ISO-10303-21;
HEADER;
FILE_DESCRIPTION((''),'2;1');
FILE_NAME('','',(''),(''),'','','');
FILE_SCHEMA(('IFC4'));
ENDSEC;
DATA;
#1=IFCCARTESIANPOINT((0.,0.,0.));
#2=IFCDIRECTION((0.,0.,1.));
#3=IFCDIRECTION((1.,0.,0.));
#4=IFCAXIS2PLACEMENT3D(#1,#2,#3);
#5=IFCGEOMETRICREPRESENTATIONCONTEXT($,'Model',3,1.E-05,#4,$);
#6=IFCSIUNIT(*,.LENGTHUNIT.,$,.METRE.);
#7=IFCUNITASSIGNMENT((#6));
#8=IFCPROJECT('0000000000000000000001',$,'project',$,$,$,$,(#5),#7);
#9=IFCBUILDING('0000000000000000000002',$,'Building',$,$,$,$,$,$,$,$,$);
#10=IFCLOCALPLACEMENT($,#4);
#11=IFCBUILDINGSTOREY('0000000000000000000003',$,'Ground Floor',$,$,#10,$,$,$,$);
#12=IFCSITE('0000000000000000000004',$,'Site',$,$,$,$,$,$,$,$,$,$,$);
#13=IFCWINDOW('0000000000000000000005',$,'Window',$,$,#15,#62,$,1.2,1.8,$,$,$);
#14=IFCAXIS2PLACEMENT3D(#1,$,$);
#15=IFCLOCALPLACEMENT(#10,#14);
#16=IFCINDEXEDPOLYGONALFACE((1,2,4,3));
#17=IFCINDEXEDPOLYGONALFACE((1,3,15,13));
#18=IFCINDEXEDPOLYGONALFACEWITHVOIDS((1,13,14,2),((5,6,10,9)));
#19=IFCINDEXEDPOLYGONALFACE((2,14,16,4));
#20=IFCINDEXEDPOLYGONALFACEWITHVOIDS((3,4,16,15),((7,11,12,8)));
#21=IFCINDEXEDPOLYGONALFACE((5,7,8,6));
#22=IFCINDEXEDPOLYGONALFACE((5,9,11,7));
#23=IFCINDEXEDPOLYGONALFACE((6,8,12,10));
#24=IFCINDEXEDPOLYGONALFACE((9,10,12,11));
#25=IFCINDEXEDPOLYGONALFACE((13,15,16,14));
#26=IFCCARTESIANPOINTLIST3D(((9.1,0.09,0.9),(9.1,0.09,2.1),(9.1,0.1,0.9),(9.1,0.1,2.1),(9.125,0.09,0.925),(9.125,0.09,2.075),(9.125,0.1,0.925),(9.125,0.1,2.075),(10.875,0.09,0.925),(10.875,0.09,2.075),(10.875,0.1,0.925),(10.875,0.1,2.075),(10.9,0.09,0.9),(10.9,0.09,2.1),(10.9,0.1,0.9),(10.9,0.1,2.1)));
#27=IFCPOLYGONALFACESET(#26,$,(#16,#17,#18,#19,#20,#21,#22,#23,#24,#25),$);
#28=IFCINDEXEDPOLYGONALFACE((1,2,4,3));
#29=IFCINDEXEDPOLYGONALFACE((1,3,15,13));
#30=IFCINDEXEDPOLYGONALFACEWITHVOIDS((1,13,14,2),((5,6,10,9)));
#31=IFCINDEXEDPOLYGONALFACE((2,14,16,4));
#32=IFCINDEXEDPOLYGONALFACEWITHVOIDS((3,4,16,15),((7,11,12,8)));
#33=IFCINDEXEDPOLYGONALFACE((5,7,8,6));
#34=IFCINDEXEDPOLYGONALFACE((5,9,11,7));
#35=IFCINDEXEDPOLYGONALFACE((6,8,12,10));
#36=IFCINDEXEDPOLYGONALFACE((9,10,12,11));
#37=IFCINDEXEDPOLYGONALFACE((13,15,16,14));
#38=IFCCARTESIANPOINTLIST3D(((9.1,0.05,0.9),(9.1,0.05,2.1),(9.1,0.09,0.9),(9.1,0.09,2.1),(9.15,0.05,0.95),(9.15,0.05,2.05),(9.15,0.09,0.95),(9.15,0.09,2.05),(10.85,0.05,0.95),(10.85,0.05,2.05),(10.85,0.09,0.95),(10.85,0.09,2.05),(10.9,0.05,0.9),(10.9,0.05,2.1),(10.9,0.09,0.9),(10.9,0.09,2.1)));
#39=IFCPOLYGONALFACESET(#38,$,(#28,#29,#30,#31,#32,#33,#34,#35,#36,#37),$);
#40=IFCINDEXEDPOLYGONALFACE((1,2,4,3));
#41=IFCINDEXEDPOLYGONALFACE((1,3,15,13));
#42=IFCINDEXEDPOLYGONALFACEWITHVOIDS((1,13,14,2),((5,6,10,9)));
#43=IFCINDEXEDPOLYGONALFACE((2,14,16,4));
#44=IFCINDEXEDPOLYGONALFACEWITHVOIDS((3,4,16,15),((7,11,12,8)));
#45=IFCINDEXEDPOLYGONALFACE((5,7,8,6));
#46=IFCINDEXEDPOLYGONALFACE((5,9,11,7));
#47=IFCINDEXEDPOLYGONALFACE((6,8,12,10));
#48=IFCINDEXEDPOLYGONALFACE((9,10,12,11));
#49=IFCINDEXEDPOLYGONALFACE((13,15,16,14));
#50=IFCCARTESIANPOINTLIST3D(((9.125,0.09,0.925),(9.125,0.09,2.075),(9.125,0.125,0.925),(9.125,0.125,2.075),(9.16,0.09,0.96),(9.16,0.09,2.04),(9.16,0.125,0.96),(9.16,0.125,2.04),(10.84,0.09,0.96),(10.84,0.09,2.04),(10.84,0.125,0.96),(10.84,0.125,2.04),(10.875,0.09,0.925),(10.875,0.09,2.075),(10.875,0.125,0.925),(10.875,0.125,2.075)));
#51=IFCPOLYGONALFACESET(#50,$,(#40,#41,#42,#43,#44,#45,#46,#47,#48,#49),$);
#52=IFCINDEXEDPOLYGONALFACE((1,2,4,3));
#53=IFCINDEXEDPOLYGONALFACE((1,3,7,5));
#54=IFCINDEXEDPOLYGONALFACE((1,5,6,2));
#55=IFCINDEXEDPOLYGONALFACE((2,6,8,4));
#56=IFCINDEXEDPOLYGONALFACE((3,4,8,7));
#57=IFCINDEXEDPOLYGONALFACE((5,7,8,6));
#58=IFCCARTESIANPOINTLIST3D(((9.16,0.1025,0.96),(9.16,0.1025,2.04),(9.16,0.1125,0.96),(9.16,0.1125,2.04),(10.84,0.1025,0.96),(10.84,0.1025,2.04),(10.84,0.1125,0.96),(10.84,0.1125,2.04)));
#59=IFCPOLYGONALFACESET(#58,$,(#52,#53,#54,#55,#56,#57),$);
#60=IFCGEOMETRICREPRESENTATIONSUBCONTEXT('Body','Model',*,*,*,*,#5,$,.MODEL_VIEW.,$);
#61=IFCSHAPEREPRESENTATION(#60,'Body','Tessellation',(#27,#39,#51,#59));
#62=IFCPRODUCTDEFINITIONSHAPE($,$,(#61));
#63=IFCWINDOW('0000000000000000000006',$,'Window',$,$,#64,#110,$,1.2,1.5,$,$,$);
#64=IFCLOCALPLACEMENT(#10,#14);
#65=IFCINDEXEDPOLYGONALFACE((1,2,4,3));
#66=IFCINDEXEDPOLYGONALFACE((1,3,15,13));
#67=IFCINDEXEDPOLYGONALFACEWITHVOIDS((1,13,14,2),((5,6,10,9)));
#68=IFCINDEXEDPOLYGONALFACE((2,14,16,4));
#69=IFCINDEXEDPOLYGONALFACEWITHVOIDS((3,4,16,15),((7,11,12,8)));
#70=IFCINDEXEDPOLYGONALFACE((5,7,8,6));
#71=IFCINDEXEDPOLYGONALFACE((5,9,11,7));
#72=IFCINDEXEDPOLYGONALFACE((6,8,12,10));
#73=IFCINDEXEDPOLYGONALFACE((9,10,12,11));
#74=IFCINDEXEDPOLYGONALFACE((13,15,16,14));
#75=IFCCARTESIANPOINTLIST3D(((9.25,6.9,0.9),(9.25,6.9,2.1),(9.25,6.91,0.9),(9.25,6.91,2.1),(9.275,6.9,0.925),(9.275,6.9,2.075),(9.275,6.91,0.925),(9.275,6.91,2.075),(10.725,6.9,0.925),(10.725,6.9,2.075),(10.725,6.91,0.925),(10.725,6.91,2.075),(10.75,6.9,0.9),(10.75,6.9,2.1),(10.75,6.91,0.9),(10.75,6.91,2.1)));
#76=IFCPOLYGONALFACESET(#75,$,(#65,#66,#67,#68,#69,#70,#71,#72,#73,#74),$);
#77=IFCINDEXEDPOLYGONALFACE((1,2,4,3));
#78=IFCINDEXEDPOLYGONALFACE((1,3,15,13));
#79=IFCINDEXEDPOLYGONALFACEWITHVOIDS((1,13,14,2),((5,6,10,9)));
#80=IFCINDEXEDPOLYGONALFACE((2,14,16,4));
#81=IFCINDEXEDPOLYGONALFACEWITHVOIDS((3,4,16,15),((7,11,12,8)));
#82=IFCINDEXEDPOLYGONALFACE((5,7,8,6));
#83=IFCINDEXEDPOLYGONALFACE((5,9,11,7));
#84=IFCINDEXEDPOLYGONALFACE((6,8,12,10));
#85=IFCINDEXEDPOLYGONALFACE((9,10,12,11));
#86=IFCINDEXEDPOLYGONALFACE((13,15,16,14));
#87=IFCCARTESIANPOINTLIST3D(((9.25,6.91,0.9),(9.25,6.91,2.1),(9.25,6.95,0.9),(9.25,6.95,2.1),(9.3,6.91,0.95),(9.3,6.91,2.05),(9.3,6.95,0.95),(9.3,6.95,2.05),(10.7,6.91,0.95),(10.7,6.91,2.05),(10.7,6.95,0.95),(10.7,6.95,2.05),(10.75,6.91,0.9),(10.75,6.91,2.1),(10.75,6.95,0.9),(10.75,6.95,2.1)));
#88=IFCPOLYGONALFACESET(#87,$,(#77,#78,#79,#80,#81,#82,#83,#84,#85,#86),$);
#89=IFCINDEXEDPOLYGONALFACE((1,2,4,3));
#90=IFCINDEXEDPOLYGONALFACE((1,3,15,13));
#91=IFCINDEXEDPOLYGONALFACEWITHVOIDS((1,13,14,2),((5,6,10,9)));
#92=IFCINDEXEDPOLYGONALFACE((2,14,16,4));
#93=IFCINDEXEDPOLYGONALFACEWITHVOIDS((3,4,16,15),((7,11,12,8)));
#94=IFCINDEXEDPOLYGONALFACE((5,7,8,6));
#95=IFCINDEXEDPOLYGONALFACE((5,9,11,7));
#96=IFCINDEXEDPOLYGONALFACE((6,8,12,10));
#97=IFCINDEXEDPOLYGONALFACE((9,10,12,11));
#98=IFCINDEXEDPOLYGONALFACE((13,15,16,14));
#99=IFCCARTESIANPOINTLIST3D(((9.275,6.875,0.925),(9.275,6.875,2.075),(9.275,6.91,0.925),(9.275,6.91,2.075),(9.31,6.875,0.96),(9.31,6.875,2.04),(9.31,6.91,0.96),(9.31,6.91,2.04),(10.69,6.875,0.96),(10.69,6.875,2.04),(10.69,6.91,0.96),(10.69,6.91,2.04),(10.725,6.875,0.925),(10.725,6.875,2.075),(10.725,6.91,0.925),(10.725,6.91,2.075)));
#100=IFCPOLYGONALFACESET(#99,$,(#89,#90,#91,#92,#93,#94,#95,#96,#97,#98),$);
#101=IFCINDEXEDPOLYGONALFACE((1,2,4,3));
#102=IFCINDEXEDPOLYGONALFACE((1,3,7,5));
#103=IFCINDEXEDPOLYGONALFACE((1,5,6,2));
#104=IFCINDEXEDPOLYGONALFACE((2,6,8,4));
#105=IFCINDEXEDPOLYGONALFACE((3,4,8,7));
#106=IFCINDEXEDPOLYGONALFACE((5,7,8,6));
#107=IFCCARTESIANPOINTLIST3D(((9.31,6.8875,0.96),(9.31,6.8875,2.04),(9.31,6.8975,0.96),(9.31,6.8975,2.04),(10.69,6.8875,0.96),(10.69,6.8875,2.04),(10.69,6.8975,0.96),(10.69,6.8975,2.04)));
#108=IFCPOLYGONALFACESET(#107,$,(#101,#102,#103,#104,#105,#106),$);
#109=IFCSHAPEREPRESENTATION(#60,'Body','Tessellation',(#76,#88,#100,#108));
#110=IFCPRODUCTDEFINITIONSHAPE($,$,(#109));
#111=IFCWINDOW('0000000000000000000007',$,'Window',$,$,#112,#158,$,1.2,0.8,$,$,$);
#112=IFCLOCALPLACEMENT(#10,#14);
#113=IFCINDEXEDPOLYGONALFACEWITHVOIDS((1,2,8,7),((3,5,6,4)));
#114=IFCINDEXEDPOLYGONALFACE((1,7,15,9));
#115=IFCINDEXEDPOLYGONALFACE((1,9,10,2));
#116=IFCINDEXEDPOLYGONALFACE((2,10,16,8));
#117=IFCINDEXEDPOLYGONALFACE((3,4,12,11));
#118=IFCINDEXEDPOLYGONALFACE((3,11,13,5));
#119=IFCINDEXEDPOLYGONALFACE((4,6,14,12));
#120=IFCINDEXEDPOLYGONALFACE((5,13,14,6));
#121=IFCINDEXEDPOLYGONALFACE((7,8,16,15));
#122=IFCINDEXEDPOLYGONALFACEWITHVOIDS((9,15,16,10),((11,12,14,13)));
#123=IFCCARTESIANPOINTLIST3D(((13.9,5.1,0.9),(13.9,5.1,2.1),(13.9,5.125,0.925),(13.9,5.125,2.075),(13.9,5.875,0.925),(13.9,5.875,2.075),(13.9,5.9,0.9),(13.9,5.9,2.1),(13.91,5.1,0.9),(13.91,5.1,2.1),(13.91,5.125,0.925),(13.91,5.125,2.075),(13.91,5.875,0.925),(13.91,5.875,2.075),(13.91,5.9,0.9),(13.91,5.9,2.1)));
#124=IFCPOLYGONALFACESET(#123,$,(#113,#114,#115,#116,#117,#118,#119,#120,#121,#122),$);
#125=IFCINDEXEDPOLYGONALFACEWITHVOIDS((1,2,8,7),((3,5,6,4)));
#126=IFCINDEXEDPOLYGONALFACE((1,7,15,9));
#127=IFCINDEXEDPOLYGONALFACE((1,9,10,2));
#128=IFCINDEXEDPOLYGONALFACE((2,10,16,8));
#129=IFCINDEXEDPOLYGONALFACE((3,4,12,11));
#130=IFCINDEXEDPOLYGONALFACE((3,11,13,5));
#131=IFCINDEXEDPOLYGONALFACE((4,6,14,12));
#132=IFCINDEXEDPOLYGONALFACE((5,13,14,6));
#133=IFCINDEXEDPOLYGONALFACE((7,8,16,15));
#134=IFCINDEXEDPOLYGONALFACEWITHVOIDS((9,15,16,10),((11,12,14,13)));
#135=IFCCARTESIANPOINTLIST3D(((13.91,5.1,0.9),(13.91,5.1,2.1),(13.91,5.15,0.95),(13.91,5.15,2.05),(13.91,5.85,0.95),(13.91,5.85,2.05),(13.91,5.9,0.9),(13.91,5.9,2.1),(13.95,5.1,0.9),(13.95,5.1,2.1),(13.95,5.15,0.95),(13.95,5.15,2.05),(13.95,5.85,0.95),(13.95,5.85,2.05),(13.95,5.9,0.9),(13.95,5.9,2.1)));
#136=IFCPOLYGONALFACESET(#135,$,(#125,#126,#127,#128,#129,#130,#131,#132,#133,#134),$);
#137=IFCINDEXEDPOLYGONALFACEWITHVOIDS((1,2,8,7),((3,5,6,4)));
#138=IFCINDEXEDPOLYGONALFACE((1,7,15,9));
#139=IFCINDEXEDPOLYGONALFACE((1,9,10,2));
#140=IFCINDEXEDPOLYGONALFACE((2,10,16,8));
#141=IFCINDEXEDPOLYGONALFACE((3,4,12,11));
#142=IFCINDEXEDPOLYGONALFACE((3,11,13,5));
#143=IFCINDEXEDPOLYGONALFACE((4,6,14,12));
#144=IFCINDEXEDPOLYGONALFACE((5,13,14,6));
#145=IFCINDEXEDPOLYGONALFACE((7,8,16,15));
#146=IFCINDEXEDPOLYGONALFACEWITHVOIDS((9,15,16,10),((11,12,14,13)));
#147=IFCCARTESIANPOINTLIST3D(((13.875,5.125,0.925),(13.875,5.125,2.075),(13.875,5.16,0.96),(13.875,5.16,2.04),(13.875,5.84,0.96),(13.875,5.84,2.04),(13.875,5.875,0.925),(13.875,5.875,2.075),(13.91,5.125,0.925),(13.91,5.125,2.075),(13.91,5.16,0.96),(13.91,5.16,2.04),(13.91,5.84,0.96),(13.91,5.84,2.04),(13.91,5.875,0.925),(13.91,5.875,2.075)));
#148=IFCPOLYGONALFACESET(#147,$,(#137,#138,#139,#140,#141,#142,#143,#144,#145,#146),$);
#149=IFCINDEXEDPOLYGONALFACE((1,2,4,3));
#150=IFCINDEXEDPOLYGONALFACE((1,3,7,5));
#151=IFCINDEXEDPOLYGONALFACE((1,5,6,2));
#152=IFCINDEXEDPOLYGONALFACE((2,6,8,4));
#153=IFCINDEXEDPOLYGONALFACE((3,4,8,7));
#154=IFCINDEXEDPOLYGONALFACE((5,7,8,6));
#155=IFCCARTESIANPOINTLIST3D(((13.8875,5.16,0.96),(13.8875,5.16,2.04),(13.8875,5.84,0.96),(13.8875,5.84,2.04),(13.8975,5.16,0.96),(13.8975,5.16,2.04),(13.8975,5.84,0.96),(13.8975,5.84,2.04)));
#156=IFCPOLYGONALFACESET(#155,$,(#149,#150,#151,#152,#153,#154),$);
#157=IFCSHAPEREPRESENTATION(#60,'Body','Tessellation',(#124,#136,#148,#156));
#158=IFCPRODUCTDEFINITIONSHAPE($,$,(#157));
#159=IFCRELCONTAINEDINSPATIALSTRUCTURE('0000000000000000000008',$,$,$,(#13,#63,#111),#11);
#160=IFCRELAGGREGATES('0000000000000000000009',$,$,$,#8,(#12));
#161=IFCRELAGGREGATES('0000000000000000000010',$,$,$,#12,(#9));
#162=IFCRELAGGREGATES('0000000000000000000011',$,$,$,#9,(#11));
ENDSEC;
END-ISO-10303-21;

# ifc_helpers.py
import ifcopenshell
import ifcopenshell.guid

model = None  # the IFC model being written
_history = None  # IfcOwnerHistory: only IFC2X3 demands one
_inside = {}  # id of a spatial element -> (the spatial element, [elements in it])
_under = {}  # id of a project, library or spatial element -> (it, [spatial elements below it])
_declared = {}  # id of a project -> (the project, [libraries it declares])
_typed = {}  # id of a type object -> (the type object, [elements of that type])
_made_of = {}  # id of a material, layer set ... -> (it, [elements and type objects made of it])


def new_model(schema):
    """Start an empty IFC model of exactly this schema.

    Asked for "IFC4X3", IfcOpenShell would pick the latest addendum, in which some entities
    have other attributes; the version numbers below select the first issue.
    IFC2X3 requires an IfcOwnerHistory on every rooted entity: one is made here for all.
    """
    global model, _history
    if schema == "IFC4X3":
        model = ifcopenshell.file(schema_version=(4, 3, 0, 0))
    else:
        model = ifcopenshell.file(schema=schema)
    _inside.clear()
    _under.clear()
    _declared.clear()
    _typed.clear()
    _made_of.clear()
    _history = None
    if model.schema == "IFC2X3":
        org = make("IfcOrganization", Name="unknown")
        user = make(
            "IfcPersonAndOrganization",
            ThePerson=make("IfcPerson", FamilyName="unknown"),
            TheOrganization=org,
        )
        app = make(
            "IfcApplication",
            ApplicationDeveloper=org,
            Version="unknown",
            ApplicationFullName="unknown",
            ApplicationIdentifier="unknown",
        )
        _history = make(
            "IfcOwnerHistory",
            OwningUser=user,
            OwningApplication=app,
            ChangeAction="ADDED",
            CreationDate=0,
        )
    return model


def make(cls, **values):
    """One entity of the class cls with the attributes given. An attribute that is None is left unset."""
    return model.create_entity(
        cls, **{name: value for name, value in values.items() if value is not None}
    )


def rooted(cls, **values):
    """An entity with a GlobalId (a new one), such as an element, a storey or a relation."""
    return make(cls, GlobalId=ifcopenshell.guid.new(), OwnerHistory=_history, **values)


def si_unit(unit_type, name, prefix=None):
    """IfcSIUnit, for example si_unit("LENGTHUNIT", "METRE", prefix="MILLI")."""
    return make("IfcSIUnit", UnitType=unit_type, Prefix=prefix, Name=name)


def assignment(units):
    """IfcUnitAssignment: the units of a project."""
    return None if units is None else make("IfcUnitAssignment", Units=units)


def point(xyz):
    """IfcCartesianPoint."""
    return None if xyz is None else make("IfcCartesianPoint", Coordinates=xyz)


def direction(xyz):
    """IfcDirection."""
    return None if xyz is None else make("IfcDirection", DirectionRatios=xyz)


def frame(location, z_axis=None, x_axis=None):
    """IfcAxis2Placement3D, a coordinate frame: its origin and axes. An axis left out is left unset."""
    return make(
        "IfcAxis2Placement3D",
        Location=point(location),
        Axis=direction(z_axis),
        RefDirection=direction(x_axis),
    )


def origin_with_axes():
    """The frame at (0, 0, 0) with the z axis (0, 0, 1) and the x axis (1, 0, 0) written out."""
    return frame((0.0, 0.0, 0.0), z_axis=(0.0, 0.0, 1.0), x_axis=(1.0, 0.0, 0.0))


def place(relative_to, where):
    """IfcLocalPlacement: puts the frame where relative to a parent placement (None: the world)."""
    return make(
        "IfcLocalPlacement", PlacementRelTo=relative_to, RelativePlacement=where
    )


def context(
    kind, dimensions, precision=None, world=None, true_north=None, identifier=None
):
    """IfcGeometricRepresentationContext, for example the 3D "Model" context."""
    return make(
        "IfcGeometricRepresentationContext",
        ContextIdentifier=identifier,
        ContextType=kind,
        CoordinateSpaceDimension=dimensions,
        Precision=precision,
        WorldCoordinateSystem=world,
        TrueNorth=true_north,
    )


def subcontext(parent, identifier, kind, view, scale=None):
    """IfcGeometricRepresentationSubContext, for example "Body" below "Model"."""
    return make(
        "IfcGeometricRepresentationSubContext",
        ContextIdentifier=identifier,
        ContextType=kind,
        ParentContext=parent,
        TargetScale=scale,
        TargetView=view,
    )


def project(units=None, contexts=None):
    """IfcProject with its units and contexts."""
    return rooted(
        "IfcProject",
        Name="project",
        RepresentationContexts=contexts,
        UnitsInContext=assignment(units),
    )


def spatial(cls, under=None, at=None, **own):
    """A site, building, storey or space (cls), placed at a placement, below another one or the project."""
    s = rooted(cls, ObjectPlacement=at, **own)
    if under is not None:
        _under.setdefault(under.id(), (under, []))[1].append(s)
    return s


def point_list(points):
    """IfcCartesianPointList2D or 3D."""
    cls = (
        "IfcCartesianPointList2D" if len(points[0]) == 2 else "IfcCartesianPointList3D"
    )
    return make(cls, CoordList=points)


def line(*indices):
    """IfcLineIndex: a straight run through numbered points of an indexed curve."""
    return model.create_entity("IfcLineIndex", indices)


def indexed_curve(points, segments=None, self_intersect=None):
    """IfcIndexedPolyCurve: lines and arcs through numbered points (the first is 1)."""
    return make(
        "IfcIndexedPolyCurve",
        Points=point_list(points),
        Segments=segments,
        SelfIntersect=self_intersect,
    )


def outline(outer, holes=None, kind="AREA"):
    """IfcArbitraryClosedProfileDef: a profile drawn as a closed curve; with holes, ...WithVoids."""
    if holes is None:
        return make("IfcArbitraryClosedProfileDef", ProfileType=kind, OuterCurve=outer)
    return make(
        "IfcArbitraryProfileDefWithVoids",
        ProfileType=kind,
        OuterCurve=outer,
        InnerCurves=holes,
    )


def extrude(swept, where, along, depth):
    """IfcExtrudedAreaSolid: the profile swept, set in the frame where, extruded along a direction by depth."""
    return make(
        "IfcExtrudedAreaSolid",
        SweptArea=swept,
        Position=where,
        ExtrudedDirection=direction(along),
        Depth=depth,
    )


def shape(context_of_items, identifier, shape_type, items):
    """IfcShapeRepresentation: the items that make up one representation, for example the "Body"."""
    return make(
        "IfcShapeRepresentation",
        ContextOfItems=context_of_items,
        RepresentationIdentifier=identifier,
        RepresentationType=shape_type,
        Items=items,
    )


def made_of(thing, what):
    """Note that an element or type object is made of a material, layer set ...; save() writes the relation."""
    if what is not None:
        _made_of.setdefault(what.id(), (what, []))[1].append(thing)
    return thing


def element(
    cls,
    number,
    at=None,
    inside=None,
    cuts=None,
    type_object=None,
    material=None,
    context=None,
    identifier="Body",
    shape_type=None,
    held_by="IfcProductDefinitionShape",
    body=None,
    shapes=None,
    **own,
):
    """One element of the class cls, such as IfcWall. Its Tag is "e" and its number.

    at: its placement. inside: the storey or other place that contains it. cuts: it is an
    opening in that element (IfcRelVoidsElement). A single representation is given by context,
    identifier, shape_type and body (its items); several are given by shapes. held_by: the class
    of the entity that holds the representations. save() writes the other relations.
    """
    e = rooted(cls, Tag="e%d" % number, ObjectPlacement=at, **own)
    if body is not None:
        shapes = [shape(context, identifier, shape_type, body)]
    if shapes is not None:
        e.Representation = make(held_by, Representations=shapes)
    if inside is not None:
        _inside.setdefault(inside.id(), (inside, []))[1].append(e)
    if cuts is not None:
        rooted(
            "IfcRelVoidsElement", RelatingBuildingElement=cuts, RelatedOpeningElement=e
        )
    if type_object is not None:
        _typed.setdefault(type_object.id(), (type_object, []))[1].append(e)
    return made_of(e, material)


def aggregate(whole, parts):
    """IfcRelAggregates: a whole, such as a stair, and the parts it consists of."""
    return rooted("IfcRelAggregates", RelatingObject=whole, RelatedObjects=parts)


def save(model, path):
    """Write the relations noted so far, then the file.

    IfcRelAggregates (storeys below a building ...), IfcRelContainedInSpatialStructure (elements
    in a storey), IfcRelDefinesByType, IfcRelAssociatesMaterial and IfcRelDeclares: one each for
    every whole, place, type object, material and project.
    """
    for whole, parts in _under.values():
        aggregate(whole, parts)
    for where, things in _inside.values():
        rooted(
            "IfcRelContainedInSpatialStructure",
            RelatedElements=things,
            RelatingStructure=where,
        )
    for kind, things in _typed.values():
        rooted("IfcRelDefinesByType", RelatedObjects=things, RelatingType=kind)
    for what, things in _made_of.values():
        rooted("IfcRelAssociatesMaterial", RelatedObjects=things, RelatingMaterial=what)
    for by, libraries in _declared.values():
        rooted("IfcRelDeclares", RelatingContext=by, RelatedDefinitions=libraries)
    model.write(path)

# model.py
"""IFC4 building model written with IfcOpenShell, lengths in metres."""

from ifc_helpers import new_model, si_unit, frame, origin_with_axes, place, context, subcontext, project, spatial, line, indexed_curve, outline, extrude, element, save


model = new_model("IFC4")

# Units and contexts
model_context = context("Model", 3, precision=1e-05, world=origin_with_axes())
body_context = subcontext(model_context, "Body", "Model", "MODEL_VIEW")
ifc_project = project(units=[si_unit("LENGTHUNIT", "METRE")], contexts=[model_context])

# Site, building, storey
site = spatial("IfcSite", under=ifc_project, Name="Site")
building = spatial("IfcBuilding", under=site, Name="Building")
storey_placement = place(None, origin_with_axes())
storey = spatial("IfcBuildingStorey", under=building, at=storey_placement, Name="Ground Floor")

# Windows
window_1_placement = place(storey_placement, frame((9.1, 0.0, 0.9), z_axis=(0.0, 0.0, 1.0), x_axis=(1.0, 0.0, 0.0)))
element("IfcWindow", 1, at=window_1_placement, inside=storey, Name="Window", OverallHeight=1.2, OverallWidth=1.8, context=body_context, shape_type="SweptSolid", body=[
    extrude(outline(indexed_curve([(0.0, 0.0), (1.8, 0.0), (1.8, 1.2), (0.0, 1.2)], segments=[line(1, 2, 3, 4, 1)]), holes=[indexed_curve([(0.025, 0.025), (1.775, 0.025), (1.775, 1.175), (0.025, 1.175)], segments=[line(1, 2, 3, 4, 1)])]), frame((0.0, 0.09, 0.0), z_axis=(0.0, -1.0, 0.0), x_axis=(1.0, 0.0, 0.0)), (0.0, 0.0, -1.0), 0.01),
    extrude(outline(indexed_curve([(0.0, 0.0), (1.8, 0.0), (1.8, 1.2), (0.0, 1.2)], segments=[line(1, 2, 3, 4, 1)]), holes=[indexed_curve([(0.05, 0.05), (1.75, 0.05), (1.75, 1.15), (0.05, 1.15)], segments=[line(1, 2, 3, 4, 1)])]), frame((0.0, 0.05, 0.0), z_axis=(0.0, -1.0, 0.0), x_axis=(1.0, 0.0, 0.0)), (0.0, 0.0, -1.0), 0.04),
    extrude(outline(indexed_curve([(0.0, 0.0), (1.75, 0.0), (1.75, 1.15), (0.0, 1.15)], segments=[line(1, 2, 3, 4, 1)]), holes=[indexed_curve([(0.035, 0.035), (1.715, 0.035), (1.715, 1.115), (0.035, 1.115)], segments=[line(1, 2, 3, 4, 1)])]), frame((0.025, 0.09, 0.025), z_axis=(0.0, -1.0, 0.0), x_axis=(1.0, 0.0, 0.0)), (0.0, 0.0, -1.0), 0.035),
    extrude(outline(indexed_curve([(0.035, 0.035), (1.715, 0.035), (1.715, 1.115), (0.035, 1.115)], segments=[line(1, 2, 3, 4, 1)])), frame((0.025, 0.1025, 0.025), z_axis=(0.0, -1.0, 0.0), x_axis=(1.0, 0.0, 0.0)), (0.0, 0.0, -1.0), 0.01),
])
window_2_placement = place(storey_placement, frame((10.75, 7.0, 0.9), z_axis=(0.0, 0.0, 1.0), x_axis=(-1.0, 0.0, 0.0)))
element("IfcWindow", 2, at=window_2_placement, inside=storey, Name="Window", OverallHeight=1.2, OverallWidth=1.5, context=body_context, shape_type="SweptSolid", body=[
    extrude(outline(indexed_curve([(0.0, 0.0), (1.5, 0.0), (1.5, 1.2), (0.0, 1.2)], segments=[line(1, 2, 3, 4, 1)]), holes=[indexed_curve([(0.025, 0.025), (1.475, 0.025), (1.475, 1.175), (0.025, 1.175)], segments=[line(1, 2, 3, 4, 1)])]), frame((0.0, 0.09, 0.0), z_axis=(0.0, -1.0, 0.0), x_axis=(1.0, 0.0, 0.0)), (0.0, 0.0, -1.0), 0.01),
    extrude(outline(indexed_curve([(0.0, 0.0), (1.5, 0.0), (1.5, 1.2), (0.0, 1.2)], segments=[line(1, 2, 3, 4, 1)]), holes=[indexed_curve([(0.05, 0.05), (1.45, 0.05), (1.45, 1.15), (0.05, 1.15)], segments=[line(1, 2, 3, 4, 1)])]), frame((0.0, 0.05, 0.0), z_axis=(0.0, -1.0, 0.0), x_axis=(1.0, 0.0, 0.0)), (0.0, 0.0, -1.0), 0.04),
    extrude(outline(indexed_curve([(0.0, 0.0), (1.45, 0.0), (1.45, 1.15), (0.0, 1.15)], segments=[line(1, 2, 3, 4, 1)]), holes=[indexed_curve([(0.035, 0.035), (1.415, 0.035), (1.415, 1.115), (0.035, 1.115)], segments=[line(1, 2, 3, 4, 1)])]), frame((0.025, 0.09, 0.025), z_axis=(0.0, -1.0, 0.0), x_axis=(1.0, 0.0, 0.0)), (0.0, 0.0, -1.0), 0.035),
    extrude(outline(indexed_curve([(0.035, 0.035), (1.415, 0.035), (1.415, 1.115), (0.035, 1.115)], segments=[line(1, 2, 3, 4, 1)])), frame((0.025, 0.1025, 0.025), z_axis=(0.0, -1.0, 0.0), x_axis=(1.0, 0.0, 0.0)), (0.0, 0.0, -1.0), 0.01),
])
window_3_placement = place(storey_placement, frame((14.0, 5.1, 0.9), z_axis=(0.0, 0.0, 1.0), x_axis=(0.0, 1.0, 0.0)))
element("IfcWindow", 3, at=window_3_placement, inside=storey, Name="Window", OverallHeight=1.2, OverallWidth=0.8, context=body_context, shape_type="SweptSolid", body=[
    extrude(outline(indexed_curve([(0.0, 0.0), (0.8, 0.0), (0.8, 1.2), (0.0, 1.2)], segments=[line(1, 2, 3, 4, 1)]), holes=[indexed_curve([(0.025, 0.025), (0.775, 0.025), (0.775, 1.175), (0.025, 1.175)], segments=[line(1, 2, 3, 4, 1)])]), frame((0.0, 0.09, 0.0), z_axis=(0.0, -1.0, 0.0), x_axis=(1.0, 0.0, 0.0)), (0.0, 0.0, -1.0), 0.01),
    extrude(outline(indexed_curve([(0.0, 0.0), (0.8, 0.0), (0.8, 1.2), (0.0, 1.2)], segments=[line(1, 2, 3, 4, 1)]), holes=[indexed_curve([(0.05, 0.05), (0.75, 0.05), (0.75, 1.15), (0.05, 1.15)], segments=[line(1, 2, 3, 4, 1)])]), frame((0.0, 0.05, 0.0), z_axis=(0.0, -1.0, 0.0), x_axis=(1.0, 0.0, 0.0)), (0.0, 0.0, -1.0), 0.04),
    extrude(outline(indexed_curve([(0.0, 0.0), (0.75, 0.0), (0.75, 1.15), (0.0, 1.15)], segments=[line(1, 2, 3, 4, 1)]), holes=[indexed_curve([(0.035, 0.035), (0.715, 0.035), (0.715, 1.115), (0.035, 1.115)], segments=[line(1, 2, 3, 4, 1)])]), frame((0.025, 0.09, 0.025), z_axis=(0.0, -1.0, 0.0), x_axis=(1.0, 0.0, 0.0)), (0.0, 0.0, -1.0), 0.035),
    extrude(outline(indexed_curve([(0.035, 0.035), (0.715, 0.035), (0.715, 1.115), (0.035, 1.115)], segments=[line(1, 2, 3, 4, 1)])), frame((0.025, 0.1025, 0.025), z_axis=(0.0, -1.0, 0.0), x_axis=(1.0, 0.0, 0.0)), (0.0, 0.0, -1.0), 0.01),
])

save(model, "model.ifc")
